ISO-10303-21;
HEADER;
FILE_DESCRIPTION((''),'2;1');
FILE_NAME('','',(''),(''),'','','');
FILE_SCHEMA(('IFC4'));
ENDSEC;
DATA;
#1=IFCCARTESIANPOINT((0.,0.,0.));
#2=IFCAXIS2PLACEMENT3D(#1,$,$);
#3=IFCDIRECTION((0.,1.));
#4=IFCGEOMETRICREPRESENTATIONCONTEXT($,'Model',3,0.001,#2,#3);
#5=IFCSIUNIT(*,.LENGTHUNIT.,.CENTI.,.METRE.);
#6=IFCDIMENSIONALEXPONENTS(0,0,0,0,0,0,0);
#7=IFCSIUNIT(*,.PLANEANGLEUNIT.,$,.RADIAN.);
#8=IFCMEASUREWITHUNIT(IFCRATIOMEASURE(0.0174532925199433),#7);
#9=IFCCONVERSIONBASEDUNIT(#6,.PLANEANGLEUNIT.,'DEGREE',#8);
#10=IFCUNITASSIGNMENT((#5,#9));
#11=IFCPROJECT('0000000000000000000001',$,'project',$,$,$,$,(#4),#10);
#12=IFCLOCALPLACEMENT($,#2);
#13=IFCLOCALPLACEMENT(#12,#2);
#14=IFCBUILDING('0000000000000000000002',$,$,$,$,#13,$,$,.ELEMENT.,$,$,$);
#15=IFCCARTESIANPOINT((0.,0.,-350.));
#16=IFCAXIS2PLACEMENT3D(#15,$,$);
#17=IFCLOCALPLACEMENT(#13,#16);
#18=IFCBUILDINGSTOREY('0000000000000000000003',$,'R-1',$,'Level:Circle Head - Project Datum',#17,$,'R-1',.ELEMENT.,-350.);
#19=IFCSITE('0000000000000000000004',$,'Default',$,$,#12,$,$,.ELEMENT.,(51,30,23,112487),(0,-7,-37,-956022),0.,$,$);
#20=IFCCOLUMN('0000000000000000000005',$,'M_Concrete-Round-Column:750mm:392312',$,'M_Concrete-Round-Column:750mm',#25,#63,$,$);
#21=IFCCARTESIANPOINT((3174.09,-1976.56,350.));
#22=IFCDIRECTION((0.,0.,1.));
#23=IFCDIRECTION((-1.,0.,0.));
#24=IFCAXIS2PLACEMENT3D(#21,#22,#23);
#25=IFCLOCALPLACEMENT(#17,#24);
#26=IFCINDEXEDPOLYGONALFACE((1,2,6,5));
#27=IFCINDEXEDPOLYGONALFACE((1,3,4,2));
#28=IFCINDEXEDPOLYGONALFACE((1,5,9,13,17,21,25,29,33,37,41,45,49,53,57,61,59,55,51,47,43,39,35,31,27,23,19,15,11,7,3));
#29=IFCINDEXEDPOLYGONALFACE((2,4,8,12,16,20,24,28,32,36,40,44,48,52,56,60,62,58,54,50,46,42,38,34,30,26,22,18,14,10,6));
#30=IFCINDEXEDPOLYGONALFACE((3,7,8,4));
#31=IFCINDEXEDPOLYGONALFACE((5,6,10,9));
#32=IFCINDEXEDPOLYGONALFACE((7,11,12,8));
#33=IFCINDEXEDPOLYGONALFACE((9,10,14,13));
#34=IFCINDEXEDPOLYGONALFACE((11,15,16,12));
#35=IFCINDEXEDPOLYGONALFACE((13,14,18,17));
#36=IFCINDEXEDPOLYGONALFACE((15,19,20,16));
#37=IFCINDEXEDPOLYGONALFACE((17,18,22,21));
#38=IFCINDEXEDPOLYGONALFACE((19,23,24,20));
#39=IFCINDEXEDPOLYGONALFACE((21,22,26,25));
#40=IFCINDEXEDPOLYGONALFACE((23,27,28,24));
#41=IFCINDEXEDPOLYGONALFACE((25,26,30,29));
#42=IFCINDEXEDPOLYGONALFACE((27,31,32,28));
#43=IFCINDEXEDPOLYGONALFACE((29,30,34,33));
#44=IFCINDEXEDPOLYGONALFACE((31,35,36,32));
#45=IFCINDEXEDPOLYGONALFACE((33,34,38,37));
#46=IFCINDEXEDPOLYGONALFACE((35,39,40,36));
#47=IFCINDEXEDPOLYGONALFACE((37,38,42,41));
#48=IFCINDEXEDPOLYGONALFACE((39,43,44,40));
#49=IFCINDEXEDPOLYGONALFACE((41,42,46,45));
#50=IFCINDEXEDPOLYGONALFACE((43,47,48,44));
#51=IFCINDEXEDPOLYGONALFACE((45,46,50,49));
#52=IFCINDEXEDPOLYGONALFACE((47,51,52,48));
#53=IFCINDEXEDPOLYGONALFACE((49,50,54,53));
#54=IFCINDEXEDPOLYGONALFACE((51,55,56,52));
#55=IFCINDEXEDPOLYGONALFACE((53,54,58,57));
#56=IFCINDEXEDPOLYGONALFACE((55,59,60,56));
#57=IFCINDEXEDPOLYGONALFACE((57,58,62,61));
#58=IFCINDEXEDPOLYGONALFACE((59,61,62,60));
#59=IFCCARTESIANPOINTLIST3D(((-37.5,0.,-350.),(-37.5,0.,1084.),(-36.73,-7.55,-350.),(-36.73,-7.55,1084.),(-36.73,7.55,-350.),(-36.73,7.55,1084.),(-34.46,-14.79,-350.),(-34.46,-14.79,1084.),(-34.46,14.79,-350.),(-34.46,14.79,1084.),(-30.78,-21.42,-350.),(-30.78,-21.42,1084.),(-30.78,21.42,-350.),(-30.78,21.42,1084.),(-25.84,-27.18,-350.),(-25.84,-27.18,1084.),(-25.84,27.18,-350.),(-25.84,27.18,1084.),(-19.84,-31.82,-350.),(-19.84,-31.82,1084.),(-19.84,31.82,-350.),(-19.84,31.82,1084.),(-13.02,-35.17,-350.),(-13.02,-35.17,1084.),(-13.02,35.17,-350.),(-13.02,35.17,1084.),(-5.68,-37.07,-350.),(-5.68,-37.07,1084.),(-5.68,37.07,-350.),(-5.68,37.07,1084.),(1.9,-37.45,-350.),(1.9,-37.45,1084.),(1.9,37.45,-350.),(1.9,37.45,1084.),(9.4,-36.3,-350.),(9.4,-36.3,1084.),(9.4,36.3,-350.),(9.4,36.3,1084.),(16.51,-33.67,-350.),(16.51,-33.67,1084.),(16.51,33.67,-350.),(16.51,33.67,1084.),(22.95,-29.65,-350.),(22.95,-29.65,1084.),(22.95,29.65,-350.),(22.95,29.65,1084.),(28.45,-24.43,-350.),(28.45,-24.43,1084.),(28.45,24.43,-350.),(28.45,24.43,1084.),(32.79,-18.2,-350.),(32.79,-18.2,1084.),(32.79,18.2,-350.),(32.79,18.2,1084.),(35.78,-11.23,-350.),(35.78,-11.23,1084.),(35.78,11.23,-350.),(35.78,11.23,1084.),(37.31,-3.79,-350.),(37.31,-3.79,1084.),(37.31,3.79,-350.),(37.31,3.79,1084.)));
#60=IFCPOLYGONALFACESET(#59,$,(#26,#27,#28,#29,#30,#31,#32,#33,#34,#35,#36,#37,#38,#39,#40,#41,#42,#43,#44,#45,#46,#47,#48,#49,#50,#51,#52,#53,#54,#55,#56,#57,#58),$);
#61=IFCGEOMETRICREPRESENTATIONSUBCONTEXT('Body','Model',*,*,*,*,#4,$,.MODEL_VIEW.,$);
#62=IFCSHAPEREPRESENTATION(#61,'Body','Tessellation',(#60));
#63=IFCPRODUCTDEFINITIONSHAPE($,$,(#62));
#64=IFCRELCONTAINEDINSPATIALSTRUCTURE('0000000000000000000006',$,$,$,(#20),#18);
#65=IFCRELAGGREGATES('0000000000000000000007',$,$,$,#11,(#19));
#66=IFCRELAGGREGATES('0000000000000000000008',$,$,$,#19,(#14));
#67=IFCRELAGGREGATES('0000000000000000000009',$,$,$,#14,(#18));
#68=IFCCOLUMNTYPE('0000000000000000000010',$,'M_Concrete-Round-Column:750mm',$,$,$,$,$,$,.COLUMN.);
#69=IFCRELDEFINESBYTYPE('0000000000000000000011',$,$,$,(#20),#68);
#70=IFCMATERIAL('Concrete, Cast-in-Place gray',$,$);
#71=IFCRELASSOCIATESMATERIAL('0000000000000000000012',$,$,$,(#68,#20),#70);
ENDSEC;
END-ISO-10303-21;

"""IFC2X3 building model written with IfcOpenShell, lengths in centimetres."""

from ifc_helpers import new_model, entity, si_unit, converted_unit, direction, frame, frame_2d, origin, place, context, subcontext, project, spatial, circle, extrude, source, transform, mapped, material, type_object, type_shapes, element, save


model = new_model("IFC2X3")

# Units and contexts
model_context = context("Model", 3, precision=0.001, world=origin(), true_north=direction((0.0, 1.0)))
body_context = subcontext(model_context, "Body", "Model", "MODEL_VIEW")
ifc_project = project(units=[si_unit("LENGTHUNIT", "METRE", prefix="CENTI"), converted_unit("PLANEANGLEUNIT", "DEGREE", entity("IfcRatioMeasure", 0.0174532925199433), si_unit("PLANEANGLEUNIT", "RADIAN"), dimensions=[0, 0, 0, 0, 0, 0, 0])], contexts=[model_context])

# Site, building, storey
site_placement = place(None, origin())
site = spatial("IfcSite", under=ifc_project, at=site_placement, Name="Default", CompositionType="ELEMENT", RefLatitude=(51, 30, 23, 112487), RefLongitude=(0, -7, -37, -956022), RefElevation=0.0)
building_placement = place(site_placement, origin())
building = spatial("IfcBuilding", under=site, at=building_placement, CompositionType="ELEMENT")
storey_placement = place(building_placement, frame((0.0, 0.0, -350.0)))
storey = spatial("IfcBuildingStorey", under=building, at=storey_placement, Name="R-1", ObjectType="Level:Circle Head - Project Datum", LongName="R-1", CompositionType="ELEMENT", Elevation=-350.0)

# Column
ifc_material_1 = material(Name="Concrete, Cast-in-Place gray")
column_type_1 = type_object("IfcColumnType", Name="M_Concrete-Round-Column:750mm", PredefinedType="COLUMN", material=ifc_material_1)
shared_shape_1 = source(origin(), body_context, "Body", "SweptSolid", [
    extrude(circle(Radius=37.5, at=frame_2d((0.0, 0.0), x_axis=(1.0, 0.0))), frame((0.0, 0.0, -350.0), z_axis=(0.0, 0.0, 1.0), x_axis=(-1.0, 0.0, 0.0)), (0.0, 0.0, 1.0), 1434.0),
])
type_shapes(column_type_1, [shared_shape_1])
column_placement = place(storey_placement, frame((3174.09, -1976.56, 350.0), z_axis=(0.0, 0.0, 1.0), x_axis=(-1.0, 0.0, 0.0)))
element("IfcColumn", 1, at=column_placement, inside=storey, type_object=column_type_1, material=ifc_material_1, Name="M_Concrete-Round-Column:750mm:392312", ObjectType="M_Concrete-Round-Column:750mm", context=body_context, shape_type="MappedRepresentation", body=[
    mapped(shared_shape_1, transform((0.0, 0.0, 0.0), scale=1.0)),
])

save(model, "model.ifc")
